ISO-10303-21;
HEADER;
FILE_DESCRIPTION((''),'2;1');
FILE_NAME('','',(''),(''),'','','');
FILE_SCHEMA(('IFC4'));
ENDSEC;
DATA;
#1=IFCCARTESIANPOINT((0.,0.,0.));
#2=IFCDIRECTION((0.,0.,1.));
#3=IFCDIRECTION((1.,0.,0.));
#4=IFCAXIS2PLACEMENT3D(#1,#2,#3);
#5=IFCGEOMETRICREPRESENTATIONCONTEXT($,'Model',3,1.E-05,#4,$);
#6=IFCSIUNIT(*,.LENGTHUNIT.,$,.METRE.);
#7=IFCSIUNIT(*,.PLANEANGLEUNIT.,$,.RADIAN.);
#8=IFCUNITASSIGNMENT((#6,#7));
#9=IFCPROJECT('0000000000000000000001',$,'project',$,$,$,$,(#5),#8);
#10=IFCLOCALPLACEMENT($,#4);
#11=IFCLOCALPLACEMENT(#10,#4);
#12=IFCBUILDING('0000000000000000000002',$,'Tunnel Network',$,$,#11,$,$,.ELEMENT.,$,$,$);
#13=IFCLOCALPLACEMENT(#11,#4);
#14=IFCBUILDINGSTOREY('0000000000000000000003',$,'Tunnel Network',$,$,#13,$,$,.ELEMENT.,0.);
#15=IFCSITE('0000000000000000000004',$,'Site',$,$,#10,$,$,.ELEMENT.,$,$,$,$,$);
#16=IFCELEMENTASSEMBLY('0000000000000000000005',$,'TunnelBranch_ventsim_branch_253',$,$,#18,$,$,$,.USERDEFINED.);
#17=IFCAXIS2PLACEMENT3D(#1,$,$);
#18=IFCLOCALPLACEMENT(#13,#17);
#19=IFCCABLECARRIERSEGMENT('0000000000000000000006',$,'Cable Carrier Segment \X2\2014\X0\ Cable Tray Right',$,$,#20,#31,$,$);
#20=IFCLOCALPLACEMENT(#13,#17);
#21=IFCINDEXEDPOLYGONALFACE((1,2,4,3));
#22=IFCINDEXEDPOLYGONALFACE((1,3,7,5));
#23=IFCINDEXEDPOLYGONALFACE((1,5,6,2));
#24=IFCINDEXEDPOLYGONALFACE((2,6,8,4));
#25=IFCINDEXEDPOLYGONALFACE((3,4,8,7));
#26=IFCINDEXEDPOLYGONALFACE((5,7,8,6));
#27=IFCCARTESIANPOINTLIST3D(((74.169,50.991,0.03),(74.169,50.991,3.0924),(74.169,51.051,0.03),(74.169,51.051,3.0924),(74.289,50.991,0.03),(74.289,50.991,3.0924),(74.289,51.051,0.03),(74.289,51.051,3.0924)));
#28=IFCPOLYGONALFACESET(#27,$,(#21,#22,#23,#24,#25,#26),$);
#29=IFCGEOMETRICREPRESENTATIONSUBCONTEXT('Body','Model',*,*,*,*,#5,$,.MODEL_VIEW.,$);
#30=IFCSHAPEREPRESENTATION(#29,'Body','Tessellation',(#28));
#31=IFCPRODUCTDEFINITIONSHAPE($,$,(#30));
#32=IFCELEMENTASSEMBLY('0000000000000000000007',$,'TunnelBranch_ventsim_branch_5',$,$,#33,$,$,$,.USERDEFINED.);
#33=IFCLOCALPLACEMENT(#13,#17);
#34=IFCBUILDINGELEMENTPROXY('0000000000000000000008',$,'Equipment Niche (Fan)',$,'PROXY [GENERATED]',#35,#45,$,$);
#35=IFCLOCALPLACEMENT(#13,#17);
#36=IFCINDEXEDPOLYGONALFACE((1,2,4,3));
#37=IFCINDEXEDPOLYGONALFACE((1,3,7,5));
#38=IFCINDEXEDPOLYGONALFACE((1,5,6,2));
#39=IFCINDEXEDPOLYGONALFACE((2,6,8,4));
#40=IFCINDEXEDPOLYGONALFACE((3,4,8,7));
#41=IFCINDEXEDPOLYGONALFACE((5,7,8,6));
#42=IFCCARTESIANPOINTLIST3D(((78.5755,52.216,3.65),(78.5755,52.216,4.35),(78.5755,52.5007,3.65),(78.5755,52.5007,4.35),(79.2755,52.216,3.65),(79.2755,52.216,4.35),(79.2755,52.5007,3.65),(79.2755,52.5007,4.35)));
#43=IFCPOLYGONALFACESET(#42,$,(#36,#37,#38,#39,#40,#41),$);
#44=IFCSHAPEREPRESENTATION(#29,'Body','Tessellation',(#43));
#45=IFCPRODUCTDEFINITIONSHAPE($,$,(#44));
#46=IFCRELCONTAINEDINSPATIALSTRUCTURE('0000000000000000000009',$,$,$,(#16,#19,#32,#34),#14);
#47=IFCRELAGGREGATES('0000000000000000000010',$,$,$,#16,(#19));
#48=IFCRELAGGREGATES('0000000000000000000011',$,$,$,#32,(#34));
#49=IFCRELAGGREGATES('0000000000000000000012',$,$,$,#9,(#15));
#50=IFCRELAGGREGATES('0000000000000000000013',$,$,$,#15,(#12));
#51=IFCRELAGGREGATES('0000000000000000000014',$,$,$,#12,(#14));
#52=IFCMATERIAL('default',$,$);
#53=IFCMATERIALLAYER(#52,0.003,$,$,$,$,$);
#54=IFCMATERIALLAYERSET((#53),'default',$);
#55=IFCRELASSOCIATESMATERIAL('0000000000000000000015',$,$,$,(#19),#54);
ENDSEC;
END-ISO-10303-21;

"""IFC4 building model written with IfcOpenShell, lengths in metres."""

from ifc_helpers import new_model, si_unit, frame, origin_with_axes, origin_2d_with_axis, place, context, subcontext, project, spatial, rectangle, extrude, material, layer, layer_set, layer_usage, element, aggregate, save


model = new_model("IFC4")

# Units and contexts
model_context = context("Model", 3, precision=1e-05, world=origin_with_axes())
body_context = subcontext(model_context, "Body", "Model", "MODEL_VIEW")
ifc_project = project(units=[si_unit("LENGTHUNIT", "METRE"), si_unit("PLANEANGLEUNIT", "RADIAN")], contexts=[model_context])

# Site, building, storey
site_placement = place(None, origin_with_axes())
site = spatial("IfcSite", under=ifc_project, at=site_placement, Name="Site", CompositionType="ELEMENT")
building_placement = place(site_placement, origin_with_axes())
building = spatial("IfcBuilding", under=site, at=building_placement, Name="Tunnel Network", CompositionType="ELEMENT")
storey_placement = place(building_placement, origin_with_axes())
storey = spatial("IfcBuildingStorey", under=building, at=storey_placement, Name="Tunnel Network", CompositionType="ELEMENT", Elevation=0.0)

# Element assembly
ifc_material_1 = material(Name="default")
ifc_layer_1 = layer(ifc_material_1, 0.003)
ifc_layer_set_1 = layer_set([ifc_layer_1], Name="default")
assembly_1_placement = place(storey_placement, frame((76.354, 51.921, 1.25), z_axis=(0.0, 1.0, 0.0), x_axis=(-1.0, 0.0, 0.0)))
assembly_1 = element("IfcElementAssembly", 1, at=assembly_1_placement, inside=storey, Name="TunnelBranch_ventsim_branch_253", PredefinedType="USERDEFINED")

# Cable carrier segment
ifc_layer_usage_1 = layer_usage(ifc_layer_set_1, "AXIS2", "POSITIVE", 0.0)
cable_carrier_segment_1_placement = place(storey_placement, frame((74.229, 51.021, 0.03), z_axis=(0.0, 0.0, 1.0), x_axis=(-1.0, 0.0, 0.0)))
cable_carrier_segment_1 = element("IfcCableCarrierSegment", 2, at=cable_carrier_segment_1_placement, inside=storey, material=ifc_layer_usage_1, Name="Cable Carrier Segment — Cable Tray Right", context=body_context, shape_type="SweptSolid", body=[
    extrude(rectangle(XDim=0.12, YDim=0.06, at=origin_2d_with_axis()), origin_with_axes(), (0.0, 0.0, 1.0), 3.0624),
])
aggregate(assembly_1, [cable_carrier_segment_1])

# Element assembly, building element proxy
assembly_2_placement = place(storey_placement, frame((78.9255, 52.216, 4.0), z_axis=(0.0, 1.0, 0.0), x_axis=(-1.0, 0.0, 0.0)))
assembly_2 = element("IfcElementAssembly", 3, at=assembly_2_placement, inside=storey, Name="TunnelBranch_ventsim_branch_5", PredefinedType="USERDEFINED")
proxy_placement = place(storey_placement, frame((78.9255, 52.216, 4.0), z_axis=(0.0, 1.0, 0.0), x_axis=(-1.0, 0.0, 0.0)))
proxy = element("IfcBuildingElementProxy", 4, at=proxy_placement, inside=storey, Name="Equipment Niche (Fan)", ObjectType="PROXY [GENERATED]", context=body_context, shape_type="SweptSolid", body=[
    extrude(rectangle(XDim=0.7, YDim=0.7, at=origin_2d_with_axis()), origin_with_axes(), (0.0, 0.0, 1.0), 0.2847),
])
aggregate(assembly_2, [proxy])

save(model, "model.ifc")
